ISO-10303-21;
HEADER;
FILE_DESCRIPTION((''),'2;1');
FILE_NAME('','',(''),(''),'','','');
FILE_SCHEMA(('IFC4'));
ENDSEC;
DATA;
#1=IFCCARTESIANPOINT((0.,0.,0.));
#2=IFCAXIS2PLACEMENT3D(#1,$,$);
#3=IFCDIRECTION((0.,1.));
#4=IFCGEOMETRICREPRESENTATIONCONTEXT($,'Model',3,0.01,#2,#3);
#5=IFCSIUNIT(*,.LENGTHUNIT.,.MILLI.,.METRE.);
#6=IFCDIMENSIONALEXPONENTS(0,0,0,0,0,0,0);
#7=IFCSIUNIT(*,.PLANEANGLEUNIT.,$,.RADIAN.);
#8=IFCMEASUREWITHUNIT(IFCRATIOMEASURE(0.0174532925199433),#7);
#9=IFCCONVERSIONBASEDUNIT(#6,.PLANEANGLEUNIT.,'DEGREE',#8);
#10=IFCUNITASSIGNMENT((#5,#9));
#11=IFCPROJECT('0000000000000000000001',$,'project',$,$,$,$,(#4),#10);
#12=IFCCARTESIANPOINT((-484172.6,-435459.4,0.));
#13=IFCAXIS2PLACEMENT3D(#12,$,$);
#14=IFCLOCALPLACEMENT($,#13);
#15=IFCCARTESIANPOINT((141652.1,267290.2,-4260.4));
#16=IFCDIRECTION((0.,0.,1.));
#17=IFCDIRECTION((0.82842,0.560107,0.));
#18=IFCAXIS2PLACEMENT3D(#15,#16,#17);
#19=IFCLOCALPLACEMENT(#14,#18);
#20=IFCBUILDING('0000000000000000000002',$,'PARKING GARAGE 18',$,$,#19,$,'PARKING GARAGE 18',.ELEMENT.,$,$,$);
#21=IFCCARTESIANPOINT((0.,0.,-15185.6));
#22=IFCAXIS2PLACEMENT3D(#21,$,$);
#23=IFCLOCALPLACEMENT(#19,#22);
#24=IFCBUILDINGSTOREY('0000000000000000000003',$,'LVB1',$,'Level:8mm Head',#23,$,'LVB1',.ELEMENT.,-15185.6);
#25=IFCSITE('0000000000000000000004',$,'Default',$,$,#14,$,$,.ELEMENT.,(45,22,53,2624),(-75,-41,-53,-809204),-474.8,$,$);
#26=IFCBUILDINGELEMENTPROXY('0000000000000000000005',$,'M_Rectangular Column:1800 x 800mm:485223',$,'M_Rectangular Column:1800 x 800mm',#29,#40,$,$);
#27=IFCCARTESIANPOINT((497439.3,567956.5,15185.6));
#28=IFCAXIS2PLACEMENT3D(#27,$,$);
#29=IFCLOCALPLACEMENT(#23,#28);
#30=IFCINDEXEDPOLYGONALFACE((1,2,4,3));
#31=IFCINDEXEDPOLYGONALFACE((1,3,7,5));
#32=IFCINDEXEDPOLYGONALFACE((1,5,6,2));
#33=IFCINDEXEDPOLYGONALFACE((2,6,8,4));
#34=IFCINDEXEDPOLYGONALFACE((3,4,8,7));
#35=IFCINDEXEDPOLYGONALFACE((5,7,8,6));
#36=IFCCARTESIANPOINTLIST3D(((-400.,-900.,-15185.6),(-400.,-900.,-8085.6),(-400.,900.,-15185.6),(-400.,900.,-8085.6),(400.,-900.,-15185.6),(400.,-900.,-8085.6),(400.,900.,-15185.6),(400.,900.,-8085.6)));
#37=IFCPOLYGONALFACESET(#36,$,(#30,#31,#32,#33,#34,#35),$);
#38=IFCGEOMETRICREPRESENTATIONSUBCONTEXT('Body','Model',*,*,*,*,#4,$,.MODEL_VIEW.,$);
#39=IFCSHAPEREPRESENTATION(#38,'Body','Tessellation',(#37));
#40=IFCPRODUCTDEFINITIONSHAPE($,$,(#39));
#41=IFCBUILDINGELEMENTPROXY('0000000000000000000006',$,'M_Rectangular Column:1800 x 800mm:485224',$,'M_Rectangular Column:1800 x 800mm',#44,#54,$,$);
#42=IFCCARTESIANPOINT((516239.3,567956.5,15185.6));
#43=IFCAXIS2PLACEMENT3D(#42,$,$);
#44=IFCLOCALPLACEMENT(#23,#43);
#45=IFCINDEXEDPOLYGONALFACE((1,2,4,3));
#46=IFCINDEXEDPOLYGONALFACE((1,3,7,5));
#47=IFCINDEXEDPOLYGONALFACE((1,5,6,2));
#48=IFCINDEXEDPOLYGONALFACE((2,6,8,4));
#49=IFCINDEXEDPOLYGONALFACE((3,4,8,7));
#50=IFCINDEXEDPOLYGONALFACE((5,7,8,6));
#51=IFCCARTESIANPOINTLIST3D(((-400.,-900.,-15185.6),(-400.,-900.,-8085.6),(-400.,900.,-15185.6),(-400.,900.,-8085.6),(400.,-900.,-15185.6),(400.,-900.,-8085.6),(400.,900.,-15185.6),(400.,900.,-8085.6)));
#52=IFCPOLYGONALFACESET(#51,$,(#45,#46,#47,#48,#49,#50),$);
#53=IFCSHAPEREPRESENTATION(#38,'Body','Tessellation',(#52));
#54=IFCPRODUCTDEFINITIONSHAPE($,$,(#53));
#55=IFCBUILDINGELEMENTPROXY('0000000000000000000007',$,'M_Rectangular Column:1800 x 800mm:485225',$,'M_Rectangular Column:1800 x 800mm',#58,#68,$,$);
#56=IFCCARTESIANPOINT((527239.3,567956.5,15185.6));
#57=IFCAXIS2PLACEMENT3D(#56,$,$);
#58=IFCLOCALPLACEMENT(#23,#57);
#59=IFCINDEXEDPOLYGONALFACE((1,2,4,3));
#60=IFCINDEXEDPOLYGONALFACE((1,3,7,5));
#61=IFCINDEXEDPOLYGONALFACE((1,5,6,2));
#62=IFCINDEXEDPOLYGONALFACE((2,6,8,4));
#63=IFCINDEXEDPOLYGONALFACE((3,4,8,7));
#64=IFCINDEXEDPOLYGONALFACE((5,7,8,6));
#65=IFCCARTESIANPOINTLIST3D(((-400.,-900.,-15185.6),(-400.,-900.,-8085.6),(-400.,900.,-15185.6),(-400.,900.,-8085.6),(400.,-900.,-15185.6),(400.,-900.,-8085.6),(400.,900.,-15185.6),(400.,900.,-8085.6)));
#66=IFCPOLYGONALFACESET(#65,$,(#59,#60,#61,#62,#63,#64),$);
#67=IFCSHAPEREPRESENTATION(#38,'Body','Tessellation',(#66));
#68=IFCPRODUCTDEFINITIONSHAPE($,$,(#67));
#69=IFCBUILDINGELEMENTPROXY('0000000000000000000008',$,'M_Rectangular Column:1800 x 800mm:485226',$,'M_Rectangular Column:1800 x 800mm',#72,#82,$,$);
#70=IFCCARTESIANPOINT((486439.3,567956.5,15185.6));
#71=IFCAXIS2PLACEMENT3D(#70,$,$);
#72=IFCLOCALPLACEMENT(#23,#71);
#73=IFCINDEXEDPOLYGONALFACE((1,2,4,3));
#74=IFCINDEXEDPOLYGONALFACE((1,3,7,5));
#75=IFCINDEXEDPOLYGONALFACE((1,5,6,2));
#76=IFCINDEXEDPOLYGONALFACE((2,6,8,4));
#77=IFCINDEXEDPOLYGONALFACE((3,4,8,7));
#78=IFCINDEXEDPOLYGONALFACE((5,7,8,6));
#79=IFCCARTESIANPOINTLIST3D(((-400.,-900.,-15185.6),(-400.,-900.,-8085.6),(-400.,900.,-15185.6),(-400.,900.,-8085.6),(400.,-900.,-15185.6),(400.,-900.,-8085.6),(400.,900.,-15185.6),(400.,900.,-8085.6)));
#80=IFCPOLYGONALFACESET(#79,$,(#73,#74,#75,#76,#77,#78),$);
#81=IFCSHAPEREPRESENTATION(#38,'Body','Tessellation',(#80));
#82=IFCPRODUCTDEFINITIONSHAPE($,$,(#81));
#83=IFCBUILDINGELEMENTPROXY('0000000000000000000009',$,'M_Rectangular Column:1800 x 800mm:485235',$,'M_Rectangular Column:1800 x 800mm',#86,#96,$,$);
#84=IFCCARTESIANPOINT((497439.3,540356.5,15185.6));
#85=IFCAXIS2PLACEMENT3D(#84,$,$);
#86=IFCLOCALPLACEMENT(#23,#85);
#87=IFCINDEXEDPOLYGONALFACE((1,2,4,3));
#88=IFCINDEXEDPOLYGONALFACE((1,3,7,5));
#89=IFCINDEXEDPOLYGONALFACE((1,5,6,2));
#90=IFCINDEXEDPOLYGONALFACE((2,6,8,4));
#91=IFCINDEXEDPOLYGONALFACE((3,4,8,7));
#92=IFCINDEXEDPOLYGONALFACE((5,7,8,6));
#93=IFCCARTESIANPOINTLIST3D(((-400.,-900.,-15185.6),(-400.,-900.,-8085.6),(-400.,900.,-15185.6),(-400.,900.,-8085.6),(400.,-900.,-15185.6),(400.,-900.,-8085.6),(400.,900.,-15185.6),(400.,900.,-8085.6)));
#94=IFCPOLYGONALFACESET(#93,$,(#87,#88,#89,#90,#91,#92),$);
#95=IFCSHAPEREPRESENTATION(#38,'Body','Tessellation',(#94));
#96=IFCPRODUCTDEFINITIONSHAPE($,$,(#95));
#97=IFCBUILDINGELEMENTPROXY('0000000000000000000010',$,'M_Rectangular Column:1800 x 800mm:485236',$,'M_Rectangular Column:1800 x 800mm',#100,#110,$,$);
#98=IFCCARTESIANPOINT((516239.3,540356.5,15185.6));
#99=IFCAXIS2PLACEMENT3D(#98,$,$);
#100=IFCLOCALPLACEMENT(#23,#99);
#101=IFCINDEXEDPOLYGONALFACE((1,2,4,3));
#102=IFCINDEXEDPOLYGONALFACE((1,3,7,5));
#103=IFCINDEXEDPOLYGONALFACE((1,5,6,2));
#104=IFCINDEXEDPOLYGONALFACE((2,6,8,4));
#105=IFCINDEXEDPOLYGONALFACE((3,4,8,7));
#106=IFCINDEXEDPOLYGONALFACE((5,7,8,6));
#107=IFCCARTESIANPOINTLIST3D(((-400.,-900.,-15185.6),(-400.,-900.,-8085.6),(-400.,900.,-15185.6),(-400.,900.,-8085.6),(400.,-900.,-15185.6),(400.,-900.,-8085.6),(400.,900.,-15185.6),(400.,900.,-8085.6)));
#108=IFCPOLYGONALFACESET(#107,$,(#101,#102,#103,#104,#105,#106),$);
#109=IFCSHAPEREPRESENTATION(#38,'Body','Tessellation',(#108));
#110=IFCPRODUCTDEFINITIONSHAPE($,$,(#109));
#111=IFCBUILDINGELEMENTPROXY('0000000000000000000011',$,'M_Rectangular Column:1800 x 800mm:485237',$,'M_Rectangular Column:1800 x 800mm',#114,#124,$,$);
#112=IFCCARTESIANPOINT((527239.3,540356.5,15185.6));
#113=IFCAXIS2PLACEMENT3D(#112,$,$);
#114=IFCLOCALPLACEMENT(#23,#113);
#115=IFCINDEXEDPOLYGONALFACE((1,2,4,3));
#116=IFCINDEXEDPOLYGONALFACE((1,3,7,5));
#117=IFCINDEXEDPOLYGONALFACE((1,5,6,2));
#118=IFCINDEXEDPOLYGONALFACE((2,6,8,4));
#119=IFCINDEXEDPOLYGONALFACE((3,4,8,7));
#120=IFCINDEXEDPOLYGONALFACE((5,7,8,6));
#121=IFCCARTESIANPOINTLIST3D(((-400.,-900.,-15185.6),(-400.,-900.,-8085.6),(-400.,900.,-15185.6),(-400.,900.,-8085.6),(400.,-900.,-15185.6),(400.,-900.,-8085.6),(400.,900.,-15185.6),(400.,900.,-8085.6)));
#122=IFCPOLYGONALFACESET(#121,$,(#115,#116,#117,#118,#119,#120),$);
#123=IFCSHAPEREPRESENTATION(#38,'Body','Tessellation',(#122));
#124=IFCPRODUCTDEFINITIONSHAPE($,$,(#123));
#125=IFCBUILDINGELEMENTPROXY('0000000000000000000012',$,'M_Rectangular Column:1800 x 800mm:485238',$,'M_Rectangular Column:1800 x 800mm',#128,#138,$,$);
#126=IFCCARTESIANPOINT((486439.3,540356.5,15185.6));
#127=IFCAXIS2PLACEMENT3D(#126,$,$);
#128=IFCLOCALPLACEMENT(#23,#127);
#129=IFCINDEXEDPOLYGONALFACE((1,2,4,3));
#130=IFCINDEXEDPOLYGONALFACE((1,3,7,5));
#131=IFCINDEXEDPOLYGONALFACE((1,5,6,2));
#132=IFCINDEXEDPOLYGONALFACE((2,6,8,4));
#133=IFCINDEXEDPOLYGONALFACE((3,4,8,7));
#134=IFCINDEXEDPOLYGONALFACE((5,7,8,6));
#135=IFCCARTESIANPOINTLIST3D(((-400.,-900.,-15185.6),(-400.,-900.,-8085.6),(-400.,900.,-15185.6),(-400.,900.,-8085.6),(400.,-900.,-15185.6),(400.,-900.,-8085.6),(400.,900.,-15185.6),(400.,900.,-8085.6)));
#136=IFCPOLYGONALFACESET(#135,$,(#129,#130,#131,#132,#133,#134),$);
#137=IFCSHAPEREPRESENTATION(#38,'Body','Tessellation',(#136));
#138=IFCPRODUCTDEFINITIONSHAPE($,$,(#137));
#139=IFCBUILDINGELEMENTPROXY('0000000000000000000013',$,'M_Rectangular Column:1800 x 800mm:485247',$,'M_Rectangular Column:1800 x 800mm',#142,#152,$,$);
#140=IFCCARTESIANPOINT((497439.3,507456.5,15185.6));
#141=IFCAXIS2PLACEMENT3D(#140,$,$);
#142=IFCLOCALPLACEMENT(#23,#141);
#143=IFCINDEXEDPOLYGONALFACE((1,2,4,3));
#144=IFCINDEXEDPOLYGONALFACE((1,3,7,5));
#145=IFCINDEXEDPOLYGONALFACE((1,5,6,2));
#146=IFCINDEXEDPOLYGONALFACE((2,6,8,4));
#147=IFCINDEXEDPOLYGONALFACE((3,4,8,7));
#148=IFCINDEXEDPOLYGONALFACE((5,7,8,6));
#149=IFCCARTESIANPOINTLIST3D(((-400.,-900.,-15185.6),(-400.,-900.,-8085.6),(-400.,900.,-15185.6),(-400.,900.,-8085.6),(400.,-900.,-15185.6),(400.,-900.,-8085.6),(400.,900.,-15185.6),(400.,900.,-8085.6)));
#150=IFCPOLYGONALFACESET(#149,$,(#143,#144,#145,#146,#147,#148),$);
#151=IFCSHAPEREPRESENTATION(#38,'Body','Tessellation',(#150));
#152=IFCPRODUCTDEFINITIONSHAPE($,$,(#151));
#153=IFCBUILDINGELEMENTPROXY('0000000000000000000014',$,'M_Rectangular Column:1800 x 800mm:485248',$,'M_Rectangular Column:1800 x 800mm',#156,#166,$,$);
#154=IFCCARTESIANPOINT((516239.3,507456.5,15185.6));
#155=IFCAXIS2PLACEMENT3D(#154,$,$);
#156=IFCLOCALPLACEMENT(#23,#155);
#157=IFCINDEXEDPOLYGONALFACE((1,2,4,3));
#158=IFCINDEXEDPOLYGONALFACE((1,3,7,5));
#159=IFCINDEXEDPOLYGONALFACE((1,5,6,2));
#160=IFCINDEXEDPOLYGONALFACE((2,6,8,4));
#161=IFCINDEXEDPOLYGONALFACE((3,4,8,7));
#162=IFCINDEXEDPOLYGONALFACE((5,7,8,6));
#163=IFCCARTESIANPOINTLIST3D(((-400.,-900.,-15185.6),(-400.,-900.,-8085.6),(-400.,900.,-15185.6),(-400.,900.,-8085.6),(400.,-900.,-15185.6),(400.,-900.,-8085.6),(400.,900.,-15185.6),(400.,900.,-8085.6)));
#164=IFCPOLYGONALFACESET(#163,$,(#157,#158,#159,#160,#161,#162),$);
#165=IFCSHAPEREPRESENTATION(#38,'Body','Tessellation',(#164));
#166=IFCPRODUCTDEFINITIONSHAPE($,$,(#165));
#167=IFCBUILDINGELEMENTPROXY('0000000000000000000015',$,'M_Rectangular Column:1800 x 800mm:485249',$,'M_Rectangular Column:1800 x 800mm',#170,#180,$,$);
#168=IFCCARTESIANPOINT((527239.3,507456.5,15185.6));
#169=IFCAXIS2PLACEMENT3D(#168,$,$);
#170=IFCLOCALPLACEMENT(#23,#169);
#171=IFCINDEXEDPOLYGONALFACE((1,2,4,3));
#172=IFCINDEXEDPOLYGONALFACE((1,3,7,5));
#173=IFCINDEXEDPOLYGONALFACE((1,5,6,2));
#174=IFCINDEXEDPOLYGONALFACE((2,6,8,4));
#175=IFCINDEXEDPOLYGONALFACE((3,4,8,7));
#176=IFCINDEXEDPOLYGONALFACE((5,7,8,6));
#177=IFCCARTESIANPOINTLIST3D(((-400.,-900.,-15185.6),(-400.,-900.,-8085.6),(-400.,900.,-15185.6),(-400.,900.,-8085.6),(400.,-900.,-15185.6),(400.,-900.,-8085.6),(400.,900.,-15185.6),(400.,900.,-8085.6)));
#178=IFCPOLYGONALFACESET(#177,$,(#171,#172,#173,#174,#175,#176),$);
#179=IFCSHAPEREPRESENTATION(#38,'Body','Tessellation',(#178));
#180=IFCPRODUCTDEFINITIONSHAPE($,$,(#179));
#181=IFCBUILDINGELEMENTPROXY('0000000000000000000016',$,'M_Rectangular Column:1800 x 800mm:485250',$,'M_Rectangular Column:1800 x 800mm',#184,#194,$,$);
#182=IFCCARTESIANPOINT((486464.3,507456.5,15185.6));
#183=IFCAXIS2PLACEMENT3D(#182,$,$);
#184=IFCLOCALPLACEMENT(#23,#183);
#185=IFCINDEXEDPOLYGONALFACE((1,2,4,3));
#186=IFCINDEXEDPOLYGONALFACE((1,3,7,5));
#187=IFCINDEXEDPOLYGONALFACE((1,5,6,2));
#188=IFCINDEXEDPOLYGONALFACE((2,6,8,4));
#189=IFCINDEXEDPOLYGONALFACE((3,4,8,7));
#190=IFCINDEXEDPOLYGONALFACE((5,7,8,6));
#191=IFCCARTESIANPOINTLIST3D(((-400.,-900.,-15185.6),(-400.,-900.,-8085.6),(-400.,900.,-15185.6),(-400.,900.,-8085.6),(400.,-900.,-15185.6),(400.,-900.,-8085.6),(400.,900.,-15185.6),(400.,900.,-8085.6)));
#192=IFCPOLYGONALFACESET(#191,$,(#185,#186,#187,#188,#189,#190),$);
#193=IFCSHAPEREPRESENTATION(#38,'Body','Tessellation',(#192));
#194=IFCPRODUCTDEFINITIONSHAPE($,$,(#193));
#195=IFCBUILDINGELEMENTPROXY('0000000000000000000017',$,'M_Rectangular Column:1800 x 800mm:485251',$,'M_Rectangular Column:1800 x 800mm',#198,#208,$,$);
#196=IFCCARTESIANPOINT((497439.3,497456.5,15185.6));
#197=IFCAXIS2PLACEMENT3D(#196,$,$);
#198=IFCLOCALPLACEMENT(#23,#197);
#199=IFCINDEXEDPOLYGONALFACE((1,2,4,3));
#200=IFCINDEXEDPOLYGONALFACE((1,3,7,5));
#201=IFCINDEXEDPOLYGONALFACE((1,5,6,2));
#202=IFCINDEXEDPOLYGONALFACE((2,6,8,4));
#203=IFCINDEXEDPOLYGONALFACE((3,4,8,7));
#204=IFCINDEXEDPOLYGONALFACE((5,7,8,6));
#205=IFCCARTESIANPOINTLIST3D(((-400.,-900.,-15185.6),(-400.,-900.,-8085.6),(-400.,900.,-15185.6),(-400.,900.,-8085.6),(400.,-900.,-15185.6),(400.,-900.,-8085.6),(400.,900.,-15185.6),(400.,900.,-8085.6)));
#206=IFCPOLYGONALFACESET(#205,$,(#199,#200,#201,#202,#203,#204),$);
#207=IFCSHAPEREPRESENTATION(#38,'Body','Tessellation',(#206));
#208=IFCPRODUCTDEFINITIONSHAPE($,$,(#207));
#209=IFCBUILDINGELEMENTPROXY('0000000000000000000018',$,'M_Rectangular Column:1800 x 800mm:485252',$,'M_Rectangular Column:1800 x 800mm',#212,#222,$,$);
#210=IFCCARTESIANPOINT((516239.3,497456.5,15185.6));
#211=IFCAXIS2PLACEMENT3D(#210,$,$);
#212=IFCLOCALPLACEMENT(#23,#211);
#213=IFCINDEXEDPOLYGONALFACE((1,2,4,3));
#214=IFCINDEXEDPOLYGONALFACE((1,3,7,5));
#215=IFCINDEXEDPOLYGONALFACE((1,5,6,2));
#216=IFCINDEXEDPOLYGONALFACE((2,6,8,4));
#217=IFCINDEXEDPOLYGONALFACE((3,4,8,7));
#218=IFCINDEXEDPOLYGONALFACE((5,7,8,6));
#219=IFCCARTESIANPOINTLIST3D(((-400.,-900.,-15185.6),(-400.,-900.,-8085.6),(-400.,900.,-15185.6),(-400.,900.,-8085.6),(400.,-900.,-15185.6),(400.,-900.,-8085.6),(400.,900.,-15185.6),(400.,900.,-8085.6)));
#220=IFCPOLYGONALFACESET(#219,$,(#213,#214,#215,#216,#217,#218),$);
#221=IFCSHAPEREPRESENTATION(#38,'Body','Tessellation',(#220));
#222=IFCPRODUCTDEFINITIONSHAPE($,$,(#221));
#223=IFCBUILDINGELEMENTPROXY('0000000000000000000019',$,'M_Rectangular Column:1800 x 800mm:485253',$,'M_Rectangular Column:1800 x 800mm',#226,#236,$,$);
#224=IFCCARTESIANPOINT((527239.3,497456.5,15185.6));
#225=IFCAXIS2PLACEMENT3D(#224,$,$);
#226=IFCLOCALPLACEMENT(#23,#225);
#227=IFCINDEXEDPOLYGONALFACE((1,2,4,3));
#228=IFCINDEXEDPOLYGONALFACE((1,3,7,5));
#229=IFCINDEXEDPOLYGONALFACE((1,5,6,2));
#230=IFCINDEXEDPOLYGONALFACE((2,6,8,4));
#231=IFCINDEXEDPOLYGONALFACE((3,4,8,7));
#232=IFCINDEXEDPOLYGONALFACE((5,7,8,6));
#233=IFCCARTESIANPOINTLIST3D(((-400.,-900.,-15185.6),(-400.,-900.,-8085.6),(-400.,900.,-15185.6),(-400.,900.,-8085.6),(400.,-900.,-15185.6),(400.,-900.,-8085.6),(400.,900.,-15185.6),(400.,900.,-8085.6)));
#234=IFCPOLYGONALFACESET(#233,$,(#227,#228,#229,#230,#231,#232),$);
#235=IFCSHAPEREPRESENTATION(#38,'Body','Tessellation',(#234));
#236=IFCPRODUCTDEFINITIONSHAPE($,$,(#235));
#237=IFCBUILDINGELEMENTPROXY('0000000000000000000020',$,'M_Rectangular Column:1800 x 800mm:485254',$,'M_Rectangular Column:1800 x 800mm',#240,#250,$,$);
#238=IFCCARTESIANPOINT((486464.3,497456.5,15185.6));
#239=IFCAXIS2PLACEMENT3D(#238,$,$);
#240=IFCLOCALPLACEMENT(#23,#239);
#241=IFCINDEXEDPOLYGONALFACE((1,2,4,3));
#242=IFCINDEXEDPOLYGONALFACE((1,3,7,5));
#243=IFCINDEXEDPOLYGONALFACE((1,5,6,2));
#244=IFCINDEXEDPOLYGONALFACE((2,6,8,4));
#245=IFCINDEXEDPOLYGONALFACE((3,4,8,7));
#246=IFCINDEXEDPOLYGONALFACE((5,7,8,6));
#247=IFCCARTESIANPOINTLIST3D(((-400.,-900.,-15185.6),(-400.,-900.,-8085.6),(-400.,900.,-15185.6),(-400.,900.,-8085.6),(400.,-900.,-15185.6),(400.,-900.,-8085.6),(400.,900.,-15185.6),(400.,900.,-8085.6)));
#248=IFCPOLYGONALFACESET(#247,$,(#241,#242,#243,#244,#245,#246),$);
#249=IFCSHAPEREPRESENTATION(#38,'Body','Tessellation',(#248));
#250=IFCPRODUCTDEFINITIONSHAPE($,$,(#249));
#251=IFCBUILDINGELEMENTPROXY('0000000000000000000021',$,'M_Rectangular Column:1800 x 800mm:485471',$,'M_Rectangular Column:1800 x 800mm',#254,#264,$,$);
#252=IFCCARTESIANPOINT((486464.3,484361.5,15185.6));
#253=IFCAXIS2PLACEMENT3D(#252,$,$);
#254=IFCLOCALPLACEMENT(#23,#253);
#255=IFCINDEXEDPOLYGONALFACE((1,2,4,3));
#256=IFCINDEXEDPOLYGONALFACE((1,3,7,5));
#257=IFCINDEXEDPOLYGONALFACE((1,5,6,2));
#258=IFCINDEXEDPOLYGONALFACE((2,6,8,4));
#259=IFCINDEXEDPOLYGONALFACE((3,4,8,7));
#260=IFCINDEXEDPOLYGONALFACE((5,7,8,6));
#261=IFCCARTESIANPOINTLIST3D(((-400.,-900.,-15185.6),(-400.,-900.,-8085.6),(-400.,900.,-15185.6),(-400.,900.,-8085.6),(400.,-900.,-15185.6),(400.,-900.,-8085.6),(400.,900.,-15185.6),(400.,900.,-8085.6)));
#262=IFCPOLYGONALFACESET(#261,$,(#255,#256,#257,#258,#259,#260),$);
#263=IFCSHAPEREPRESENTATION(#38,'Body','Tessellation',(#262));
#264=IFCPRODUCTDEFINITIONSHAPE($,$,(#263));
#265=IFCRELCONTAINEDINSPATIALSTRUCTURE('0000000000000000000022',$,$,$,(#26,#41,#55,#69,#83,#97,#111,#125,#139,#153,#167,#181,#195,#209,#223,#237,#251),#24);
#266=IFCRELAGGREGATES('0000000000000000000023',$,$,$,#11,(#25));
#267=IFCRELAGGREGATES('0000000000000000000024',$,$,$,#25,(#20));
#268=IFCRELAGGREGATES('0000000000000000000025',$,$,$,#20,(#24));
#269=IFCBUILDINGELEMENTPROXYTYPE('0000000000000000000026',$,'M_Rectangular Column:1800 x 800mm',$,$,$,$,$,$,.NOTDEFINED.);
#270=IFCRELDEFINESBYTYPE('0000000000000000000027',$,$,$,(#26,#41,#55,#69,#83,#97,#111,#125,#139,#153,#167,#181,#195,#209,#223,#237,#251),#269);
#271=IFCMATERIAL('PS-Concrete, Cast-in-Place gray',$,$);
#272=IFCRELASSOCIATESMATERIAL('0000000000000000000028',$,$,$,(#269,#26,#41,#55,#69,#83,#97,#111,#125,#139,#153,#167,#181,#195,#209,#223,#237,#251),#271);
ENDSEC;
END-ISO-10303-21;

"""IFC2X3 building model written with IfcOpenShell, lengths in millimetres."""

from ifc_helpers import new_model, entity, si_unit, converted_unit, direction, frame, origin, origin_2d_with_axis, place, context, subcontext, project, spatial, rectangle, extrude, source, transform, mapped, material, type_object, type_shapes, element, save


model = new_model("IFC2X3")

# Units and contexts
model_context = context("Model", 3, precision=0.01, world=origin(), true_north=direction((0.0, 1.0)))
body_context = subcontext(model_context, "Body", "Model", "MODEL_VIEW")
ifc_project = project(units=[si_unit("LENGTHUNIT", "METRE", prefix="MILLI"), converted_unit("PLANEANGLEUNIT", "DEGREE", entity("IfcRatioMeasure", 0.0174532925199433), si_unit("PLANEANGLEUNIT", "RADIAN"), dimensions=[0, 0, 0, 0, 0, 0, 0])], contexts=[model_context])

# Site, building, storey
site_placement = place(None, frame((-484172.6, -435459.4, 0.0)))
site = spatial("IfcSite", under=ifc_project, at=site_placement, Name="Default", CompositionType="ELEMENT", RefLatitude=(45, 22, 53, 2624), RefLongitude=(-75, -41, -53, -809204), RefElevation=-474.8)
building_placement = place(site_placement, frame((141652.1, 267290.2, -4260.4), z_axis=(0.0, 0.0, 1.0), x_axis=(0.82842, 0.560107, 0.0)))
building = spatial("IfcBuilding", under=site, at=building_placement, Name="PARKING GARAGE 18", LongName="PARKING GARAGE 18", CompositionType="ELEMENT")
storey_placement = place(building_placement, frame((0.0, 0.0, -15185.6)))
storey = spatial("IfcBuildingStorey", under=building, at=storey_placement, Name="LVB1", ObjectType="Level:8mm Head", LongName="LVB1", CompositionType="ELEMENT", Elevation=-15185.6)

# Building element proxies
ifc_material = material(Name="PS-Concrete, Cast-in-Place gray")
building_element_proxy_type_1 = type_object("IfcBuildingElementProxyType", Name="M_Rectangular Column:1800 x 800mm", PredefinedType="NOTDEFINED", material=ifc_material)
shared_shape_1 = source(origin(), body_context, "Body", "SweptSolid", [
    extrude(rectangle(XDim=800.0, YDim=1800.0, at=origin_2d_with_axis()), frame((0.0, 0.0, -15185.6), z_axis=(0.0, 0.0, 1.0), x_axis=(-1.0, 0.0, 0.0)), (0.0, 0.0, 1.0), 7100.0),
])
type_shapes(building_element_proxy_type_1, [shared_shape_1])
for number, where, name in (
    (1, (497439.3, 567956.5, 15185.6), "M_Rectangular Column:1800 x 800mm:485223"),
    (2, (516239.3, 567956.5, 15185.6), "M_Rectangular Column:1800 x 800mm:485224"),
    (3, (527239.3, 567956.5, 15185.6), "M_Rectangular Column:1800 x 800mm:485225"),
    (4, (486439.3, 567956.5, 15185.6), "M_Rectangular Column:1800 x 800mm:485226"),
    (5, (497439.3, 540356.5, 15185.6), "M_Rectangular Column:1800 x 800mm:485235"),
    (6, (516239.3, 540356.5, 15185.6), "M_Rectangular Column:1800 x 800mm:485236"),
    (7, (527239.3, 540356.5, 15185.6), "M_Rectangular Column:1800 x 800mm:485237"),
    (8, (486439.3, 540356.5, 15185.6), "M_Rectangular Column:1800 x 800mm:485238"),
    (9, (497439.3, 507456.5, 15185.6), "M_Rectangular Column:1800 x 800mm:485247"),
    (10, (516239.3, 507456.5, 15185.6), "M_Rectangular Column:1800 x 800mm:485248"),
    (11, (527239.3, 507456.5, 15185.6), "M_Rectangular Column:1800 x 800mm:485249"),
    (12, (486464.3, 507456.5, 15185.6), "M_Rectangular Column:1800 x 800mm:485250"),
    (13, (497439.3, 497456.5, 15185.6), "M_Rectangular Column:1800 x 800mm:485251"),
    (14, (516239.3, 497456.5, 15185.6), "M_Rectangular Column:1800 x 800mm:485252"),
    (15, (527239.3, 497456.5, 15185.6), "M_Rectangular Column:1800 x 800mm:485253"),
    (16, (486464.3, 497456.5, 15185.6), "M_Rectangular Column:1800 x 800mm:485254"),
    (17, (486464.3, 484361.5, 15185.6), "M_Rectangular Column:1800 x 800mm:485471"),
):
    element("IfcBuildingElementProxy", number, at=place(storey_placement, frame(where)), inside=storey, type_object=building_element_proxy_type_1, material=ifc_material, Name=name, ObjectType="M_Rectangular Column:1800 x 800mm", context=body_context, shape_type="MappedRepresentation", body=[
        mapped(shared_shape_1, transform((0.0, 0.0, 0.0), scale=1.0)),
    ])

save(model, "model.ifc")
